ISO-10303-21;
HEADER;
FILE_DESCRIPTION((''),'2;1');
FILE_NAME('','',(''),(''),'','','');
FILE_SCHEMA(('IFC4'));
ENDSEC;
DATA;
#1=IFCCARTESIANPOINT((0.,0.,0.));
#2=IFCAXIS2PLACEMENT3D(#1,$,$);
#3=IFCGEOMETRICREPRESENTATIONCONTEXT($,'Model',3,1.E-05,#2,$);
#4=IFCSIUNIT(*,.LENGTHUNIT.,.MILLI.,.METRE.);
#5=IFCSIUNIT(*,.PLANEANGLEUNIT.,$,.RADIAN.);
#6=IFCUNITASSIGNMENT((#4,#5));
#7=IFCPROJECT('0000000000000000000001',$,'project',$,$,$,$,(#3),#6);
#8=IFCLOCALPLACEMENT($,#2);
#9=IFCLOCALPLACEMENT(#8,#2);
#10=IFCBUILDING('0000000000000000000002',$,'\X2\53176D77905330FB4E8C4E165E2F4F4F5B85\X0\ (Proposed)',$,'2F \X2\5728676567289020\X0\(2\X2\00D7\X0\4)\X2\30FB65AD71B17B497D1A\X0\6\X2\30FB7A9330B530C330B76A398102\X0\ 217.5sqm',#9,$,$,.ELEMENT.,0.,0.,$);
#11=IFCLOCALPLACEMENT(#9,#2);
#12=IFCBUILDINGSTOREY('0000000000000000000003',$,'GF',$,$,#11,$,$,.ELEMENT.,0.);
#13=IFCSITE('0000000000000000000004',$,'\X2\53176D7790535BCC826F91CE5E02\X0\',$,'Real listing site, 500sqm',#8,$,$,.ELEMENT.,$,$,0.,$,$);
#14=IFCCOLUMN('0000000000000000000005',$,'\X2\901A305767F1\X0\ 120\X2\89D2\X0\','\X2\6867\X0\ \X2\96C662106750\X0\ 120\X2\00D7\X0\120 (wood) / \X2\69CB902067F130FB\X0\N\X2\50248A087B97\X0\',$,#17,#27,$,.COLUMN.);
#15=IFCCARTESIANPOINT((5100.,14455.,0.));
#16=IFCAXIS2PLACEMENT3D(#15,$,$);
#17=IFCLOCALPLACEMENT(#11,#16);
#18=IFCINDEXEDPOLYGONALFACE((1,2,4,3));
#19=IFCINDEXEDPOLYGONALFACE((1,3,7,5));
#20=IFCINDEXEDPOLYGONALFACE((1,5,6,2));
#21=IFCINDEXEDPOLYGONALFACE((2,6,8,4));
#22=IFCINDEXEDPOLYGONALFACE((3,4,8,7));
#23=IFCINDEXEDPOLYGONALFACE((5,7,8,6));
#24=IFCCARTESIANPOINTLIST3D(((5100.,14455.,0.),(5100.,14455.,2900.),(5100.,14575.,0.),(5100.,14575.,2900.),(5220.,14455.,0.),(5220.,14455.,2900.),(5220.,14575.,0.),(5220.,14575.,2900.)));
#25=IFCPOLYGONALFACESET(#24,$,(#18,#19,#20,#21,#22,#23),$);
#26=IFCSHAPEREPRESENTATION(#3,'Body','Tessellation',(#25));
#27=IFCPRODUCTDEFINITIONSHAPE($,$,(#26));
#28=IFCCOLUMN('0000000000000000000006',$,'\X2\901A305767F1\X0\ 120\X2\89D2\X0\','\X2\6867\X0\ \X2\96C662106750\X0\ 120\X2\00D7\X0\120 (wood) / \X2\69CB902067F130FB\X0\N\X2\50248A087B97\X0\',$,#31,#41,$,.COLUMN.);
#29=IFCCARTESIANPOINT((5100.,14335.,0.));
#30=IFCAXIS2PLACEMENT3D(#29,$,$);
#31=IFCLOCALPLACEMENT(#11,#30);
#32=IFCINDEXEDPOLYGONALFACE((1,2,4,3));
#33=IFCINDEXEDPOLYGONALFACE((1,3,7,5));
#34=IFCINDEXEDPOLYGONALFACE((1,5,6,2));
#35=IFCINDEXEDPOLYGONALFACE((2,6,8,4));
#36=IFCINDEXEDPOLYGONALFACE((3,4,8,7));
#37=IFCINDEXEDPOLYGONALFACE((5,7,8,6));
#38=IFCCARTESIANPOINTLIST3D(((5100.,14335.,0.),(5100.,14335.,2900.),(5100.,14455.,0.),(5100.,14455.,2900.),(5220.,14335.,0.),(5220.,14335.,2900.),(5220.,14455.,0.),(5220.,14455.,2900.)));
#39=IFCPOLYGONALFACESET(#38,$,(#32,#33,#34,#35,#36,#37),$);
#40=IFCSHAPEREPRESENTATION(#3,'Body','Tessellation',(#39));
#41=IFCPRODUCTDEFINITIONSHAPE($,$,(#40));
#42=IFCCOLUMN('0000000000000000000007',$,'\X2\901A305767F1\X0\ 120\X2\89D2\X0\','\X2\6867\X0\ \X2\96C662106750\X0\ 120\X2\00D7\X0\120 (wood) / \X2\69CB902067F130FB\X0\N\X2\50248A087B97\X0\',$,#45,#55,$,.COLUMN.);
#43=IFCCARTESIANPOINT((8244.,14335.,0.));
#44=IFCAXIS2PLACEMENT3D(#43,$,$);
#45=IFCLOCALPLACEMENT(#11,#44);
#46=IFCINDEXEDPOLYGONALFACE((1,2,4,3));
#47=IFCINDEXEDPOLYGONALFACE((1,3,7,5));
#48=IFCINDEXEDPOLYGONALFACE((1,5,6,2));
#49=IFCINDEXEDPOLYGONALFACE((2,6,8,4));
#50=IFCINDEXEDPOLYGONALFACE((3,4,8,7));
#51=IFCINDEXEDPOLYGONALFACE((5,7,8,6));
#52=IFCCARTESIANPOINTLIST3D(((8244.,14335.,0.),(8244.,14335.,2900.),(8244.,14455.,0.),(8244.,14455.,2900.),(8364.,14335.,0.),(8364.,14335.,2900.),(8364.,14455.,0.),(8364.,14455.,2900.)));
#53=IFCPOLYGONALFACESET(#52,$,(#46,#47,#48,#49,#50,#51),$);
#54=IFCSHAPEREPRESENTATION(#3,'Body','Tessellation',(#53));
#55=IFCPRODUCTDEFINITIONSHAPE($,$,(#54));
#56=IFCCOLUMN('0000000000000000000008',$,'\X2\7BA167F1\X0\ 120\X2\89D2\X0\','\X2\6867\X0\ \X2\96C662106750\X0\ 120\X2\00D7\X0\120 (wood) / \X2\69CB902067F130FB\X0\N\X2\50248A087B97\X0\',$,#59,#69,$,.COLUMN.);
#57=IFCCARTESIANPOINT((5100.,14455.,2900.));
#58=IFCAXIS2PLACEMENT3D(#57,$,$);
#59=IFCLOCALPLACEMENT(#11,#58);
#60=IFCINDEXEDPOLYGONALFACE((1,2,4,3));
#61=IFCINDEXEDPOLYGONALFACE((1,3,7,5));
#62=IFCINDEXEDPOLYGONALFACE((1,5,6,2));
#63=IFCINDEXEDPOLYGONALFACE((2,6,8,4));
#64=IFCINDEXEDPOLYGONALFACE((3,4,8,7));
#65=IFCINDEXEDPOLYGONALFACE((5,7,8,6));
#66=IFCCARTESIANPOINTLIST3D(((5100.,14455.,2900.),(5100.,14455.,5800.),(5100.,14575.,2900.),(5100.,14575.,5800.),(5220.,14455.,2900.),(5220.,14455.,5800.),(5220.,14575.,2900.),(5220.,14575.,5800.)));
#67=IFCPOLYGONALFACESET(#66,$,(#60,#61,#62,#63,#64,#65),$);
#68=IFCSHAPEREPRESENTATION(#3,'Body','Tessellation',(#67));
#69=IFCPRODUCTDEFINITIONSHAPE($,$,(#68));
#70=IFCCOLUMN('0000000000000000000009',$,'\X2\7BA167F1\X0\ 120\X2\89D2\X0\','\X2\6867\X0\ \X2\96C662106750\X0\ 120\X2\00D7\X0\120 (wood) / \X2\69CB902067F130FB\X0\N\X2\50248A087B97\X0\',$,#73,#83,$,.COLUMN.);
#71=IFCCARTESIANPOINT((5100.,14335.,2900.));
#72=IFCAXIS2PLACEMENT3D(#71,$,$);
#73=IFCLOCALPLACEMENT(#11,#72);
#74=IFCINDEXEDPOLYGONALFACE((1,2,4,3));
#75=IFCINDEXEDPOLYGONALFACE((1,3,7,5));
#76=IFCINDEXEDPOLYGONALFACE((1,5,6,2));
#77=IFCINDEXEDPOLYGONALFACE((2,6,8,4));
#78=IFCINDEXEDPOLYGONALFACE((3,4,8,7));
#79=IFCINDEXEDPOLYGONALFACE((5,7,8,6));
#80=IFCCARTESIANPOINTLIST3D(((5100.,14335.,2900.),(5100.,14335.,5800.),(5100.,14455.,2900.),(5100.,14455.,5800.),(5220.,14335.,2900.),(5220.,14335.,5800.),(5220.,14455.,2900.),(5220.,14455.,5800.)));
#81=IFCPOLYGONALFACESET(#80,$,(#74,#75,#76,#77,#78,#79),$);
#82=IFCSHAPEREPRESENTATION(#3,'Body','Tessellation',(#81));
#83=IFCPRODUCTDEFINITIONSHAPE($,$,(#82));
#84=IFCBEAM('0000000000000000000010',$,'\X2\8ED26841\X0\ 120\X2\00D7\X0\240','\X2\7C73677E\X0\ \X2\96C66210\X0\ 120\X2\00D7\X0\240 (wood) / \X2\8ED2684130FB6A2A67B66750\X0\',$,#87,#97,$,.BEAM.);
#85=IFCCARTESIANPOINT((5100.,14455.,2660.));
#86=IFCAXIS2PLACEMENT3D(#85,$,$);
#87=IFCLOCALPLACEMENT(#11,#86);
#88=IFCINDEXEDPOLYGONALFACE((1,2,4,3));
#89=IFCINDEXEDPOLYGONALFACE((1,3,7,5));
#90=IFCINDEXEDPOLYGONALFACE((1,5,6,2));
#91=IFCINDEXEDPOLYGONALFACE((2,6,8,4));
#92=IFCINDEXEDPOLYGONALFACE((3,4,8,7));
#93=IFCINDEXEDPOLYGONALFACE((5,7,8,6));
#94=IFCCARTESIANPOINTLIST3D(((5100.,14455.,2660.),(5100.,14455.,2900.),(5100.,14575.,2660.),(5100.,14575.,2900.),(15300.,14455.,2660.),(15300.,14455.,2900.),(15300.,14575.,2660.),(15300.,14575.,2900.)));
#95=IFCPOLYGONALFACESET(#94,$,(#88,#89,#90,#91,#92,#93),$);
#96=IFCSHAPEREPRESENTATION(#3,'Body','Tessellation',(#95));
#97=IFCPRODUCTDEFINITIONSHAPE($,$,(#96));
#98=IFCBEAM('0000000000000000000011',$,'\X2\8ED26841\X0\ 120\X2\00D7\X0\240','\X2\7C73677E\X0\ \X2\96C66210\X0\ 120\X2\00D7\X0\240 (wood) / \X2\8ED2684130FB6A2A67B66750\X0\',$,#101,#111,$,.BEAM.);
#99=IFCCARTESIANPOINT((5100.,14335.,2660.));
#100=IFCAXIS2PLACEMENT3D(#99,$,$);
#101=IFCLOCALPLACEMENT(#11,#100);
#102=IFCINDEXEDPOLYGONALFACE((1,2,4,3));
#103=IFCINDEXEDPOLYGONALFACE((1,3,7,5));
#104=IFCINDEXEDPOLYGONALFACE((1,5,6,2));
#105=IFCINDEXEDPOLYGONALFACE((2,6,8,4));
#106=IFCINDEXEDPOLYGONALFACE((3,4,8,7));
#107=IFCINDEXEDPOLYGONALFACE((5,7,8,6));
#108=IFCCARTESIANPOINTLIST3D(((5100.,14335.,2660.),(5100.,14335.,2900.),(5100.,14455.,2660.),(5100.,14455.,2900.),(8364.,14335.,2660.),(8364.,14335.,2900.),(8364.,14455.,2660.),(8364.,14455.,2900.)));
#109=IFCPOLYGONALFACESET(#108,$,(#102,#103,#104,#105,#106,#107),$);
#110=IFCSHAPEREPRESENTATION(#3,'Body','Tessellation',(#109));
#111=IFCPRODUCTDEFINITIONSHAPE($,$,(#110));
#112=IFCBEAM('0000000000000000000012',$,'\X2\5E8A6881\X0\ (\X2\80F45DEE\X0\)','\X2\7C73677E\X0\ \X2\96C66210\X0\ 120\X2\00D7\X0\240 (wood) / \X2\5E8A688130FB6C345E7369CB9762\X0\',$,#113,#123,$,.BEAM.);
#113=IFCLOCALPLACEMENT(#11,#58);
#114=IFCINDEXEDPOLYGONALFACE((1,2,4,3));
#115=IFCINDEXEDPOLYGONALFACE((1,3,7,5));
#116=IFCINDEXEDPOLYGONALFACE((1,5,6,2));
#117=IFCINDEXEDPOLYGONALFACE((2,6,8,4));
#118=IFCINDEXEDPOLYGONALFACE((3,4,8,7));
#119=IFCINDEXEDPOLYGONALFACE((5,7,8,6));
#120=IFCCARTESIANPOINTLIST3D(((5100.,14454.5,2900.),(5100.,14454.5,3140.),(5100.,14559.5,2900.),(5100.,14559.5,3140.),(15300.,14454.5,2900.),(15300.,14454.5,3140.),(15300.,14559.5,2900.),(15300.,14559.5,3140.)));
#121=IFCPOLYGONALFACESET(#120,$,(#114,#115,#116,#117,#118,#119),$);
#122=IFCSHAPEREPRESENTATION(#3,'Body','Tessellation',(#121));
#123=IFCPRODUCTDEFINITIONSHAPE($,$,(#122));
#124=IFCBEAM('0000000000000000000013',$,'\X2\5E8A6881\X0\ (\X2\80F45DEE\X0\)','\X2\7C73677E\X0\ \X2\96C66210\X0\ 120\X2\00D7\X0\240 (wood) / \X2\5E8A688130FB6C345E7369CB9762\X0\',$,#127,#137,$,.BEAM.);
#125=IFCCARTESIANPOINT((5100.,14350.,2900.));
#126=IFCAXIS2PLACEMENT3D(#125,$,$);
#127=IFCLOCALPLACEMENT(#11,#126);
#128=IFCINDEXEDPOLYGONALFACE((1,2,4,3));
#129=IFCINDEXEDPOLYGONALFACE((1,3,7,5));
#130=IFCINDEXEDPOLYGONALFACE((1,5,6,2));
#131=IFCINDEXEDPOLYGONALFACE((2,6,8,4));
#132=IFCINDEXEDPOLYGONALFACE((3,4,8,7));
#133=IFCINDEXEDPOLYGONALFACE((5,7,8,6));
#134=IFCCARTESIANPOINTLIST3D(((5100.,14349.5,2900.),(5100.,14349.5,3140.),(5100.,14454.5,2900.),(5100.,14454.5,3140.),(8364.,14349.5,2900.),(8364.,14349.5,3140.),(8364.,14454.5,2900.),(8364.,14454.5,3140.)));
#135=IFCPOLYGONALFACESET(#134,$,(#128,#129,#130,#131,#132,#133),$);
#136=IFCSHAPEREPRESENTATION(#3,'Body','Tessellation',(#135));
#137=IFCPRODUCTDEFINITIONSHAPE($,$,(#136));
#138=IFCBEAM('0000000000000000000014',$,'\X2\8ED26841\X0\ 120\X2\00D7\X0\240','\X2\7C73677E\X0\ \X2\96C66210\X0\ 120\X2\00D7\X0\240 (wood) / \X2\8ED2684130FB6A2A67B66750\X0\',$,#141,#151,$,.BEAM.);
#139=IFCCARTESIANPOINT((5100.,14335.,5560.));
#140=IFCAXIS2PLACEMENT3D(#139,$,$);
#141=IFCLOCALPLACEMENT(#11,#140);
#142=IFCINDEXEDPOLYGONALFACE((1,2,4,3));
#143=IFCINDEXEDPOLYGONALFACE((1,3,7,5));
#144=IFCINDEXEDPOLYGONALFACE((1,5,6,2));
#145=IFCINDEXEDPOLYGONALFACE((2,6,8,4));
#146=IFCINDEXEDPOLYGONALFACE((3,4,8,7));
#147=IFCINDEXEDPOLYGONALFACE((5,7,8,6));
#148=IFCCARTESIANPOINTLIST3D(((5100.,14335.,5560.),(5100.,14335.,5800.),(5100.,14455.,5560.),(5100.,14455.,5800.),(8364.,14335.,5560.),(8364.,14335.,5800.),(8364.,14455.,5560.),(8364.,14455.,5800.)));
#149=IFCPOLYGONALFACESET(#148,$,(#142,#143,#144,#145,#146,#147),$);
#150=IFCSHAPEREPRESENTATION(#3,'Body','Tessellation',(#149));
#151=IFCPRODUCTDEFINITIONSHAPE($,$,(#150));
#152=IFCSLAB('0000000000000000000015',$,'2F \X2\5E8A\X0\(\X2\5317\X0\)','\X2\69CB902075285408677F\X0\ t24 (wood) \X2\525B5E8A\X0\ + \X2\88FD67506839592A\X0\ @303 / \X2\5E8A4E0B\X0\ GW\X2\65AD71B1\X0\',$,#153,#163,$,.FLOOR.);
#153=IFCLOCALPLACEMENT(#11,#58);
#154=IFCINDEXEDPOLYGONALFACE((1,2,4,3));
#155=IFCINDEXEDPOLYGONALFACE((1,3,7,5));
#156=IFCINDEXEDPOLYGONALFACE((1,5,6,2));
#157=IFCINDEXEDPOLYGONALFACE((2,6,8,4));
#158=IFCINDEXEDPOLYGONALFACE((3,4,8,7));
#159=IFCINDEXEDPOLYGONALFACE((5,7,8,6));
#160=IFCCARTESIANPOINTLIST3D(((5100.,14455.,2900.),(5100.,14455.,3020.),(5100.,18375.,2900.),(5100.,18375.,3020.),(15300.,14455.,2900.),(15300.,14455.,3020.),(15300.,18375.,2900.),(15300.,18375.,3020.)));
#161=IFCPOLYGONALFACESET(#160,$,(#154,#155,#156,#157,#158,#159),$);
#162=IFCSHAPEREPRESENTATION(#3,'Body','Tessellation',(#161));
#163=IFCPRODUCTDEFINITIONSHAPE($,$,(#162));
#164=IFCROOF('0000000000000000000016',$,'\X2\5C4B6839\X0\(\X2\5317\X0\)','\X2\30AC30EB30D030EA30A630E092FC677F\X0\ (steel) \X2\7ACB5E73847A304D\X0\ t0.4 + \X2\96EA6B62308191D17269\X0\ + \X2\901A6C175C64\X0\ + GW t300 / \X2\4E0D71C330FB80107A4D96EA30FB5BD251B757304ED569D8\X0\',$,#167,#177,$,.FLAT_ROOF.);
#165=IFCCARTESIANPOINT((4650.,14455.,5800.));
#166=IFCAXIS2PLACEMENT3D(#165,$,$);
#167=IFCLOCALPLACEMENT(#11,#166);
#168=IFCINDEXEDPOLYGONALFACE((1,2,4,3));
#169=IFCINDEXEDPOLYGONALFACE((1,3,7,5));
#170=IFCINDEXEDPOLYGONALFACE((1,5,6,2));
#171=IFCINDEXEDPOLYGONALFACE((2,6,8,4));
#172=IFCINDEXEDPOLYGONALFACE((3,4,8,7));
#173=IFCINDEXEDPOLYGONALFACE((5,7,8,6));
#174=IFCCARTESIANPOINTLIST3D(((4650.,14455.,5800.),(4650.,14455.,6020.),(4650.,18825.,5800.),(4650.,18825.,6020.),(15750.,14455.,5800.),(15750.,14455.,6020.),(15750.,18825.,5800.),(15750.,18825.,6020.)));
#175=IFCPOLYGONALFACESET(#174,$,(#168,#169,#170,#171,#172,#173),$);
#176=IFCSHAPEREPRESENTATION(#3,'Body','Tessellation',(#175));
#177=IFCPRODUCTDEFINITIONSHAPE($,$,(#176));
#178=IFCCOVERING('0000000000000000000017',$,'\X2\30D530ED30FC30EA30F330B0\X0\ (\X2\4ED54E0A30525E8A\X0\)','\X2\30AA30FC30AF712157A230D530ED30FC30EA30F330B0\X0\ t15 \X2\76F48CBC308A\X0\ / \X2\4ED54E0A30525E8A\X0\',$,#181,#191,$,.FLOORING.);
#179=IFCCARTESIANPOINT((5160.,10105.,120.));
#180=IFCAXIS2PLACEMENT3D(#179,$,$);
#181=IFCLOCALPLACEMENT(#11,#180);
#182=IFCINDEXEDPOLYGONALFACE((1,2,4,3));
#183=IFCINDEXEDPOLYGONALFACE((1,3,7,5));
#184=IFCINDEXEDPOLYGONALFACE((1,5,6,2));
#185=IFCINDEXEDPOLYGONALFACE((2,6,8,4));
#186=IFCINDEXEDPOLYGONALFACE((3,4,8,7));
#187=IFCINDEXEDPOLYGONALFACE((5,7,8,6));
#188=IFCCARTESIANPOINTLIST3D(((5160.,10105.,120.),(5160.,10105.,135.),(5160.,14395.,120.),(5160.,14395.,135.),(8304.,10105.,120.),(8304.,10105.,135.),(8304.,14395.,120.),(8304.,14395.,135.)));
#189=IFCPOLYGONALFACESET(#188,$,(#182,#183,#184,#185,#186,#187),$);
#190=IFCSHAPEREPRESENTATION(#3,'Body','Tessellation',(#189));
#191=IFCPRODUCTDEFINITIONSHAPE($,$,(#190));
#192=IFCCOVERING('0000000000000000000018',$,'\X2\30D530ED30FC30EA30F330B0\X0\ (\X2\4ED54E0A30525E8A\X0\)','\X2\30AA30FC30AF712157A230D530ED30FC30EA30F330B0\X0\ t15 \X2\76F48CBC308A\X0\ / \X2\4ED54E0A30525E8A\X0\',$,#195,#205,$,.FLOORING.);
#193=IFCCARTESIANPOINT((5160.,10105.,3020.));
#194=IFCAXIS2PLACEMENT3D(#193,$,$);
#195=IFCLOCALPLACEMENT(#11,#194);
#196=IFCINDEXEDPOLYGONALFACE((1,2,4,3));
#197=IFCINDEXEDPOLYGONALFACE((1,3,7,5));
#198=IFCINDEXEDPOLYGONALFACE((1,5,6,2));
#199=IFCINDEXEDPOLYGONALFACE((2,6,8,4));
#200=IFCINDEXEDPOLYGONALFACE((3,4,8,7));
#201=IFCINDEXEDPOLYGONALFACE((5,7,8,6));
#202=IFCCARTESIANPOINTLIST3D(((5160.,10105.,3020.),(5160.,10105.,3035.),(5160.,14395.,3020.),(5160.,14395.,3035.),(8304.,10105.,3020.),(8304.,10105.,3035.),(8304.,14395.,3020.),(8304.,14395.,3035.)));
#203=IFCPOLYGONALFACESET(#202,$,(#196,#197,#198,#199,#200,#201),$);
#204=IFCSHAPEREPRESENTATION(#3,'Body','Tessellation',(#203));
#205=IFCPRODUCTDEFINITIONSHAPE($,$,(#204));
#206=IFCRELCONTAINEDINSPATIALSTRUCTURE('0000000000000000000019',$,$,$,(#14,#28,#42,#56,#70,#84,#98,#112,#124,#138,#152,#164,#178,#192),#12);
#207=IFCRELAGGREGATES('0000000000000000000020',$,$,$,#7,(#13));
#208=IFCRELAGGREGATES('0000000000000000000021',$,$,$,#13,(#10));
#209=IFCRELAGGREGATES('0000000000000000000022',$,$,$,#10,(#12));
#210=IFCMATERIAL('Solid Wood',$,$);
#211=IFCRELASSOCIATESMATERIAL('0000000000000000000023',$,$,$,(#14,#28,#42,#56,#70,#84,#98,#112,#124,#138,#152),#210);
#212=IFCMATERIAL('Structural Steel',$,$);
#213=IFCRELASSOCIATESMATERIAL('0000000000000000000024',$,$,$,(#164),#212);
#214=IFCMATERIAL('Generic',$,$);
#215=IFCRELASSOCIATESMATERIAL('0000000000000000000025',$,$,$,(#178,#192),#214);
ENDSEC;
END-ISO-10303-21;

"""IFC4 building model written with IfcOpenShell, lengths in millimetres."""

from ifc_helpers import new_model, si_unit, frame, frame_2d, origin, place, context, project, spatial, rectangle, extrude, material, element, save


model = new_model("IFC4")

# Units and contexts
model_context = context("Model", 3, precision=1e-05, world=origin())
ifc_project = project(units=[si_unit("LENGTHUNIT", "METRE", prefix="MILLI"), si_unit("PLANEANGLEUNIT", "RADIAN")], contexts=[model_context])

# Site, building, storey
site_placement = place(None, origin())
site = spatial("IfcSite", under=ifc_project, at=site_placement, Name="北海道富良野市", ObjectType="Real listing site, 500sqm", CompositionType="ELEMENT", RefElevation=0.0)
building_placement = place(site_placement, origin())
building = spatial("IfcBuilding", under=site, at=building_placement, Name="北海道・二世帯住宅 (Proposed)", ObjectType="2F 在来木造(2×4)・断熱等級6・窓サッシ樹脂 217.5sqm", CompositionType="ELEMENT", ElevationOfRefHeight=0.0, ElevationOfTerrain=0.0)
storey_placement = place(building_placement, origin())
storey = spatial("IfcBuildingStorey", under=building, at=storey_placement, Name="GF", CompositionType="ELEMENT", Elevation=0.0)

# Columns
ifc_material_1 = material(Name="Solid Wood")
column_1_placement = place(storey_placement, frame((5100.0, 14455.0, 0.0)))
element("IfcColumn", 1, at=column_1_placement, inside=storey, material=ifc_material_1, Name="通し柱 120角", Description="桧 集成材 120×120 (wood) / 構造柱・N値計算", PredefinedType="COLUMN", context=model_context, shape_type="SweptSolid", body=[
    extrude(rectangle(XDim=120.0, YDim=120.0, at=frame_2d((60.0, 60.0))), frame((5100.0, 14455.0, 0.0)), (0.0, 0.0, 1.0), 2900.0),
])
column_2_placement = place(storey_placement, frame((5100.0, 14335.0, 0.0)))
element("IfcColumn", 2, at=column_2_placement, inside=storey, material=ifc_material_1, Name="通し柱 120角", Description="桧 集成材 120×120 (wood) / 構造柱・N値計算", PredefinedType="COLUMN", context=model_context, shape_type="SweptSolid", body=[
    extrude(rectangle(XDim=120.0, YDim=120.0, at=frame_2d((60.0, 60.0))), frame((5100.0, 14335.0, 0.0)), (0.0, 0.0, 1.0), 2900.0),
])
column_3_placement = place(storey_placement, frame((8244.0, 14335.0, 0.0)))
element("IfcColumn", 3, at=column_3_placement, inside=storey, material=ifc_material_1, Name="通し柱 120角", Description="桧 集成材 120×120 (wood) / 構造柱・N値計算", PredefinedType="COLUMN", context=model_context, shape_type="SweptSolid", body=[
    extrude(rectangle(XDim=120.0, YDim=120.0, at=frame_2d((60.0, 60.0))), frame((8244.0, 14335.0, 0.0)), (0.0, 0.0, 1.0), 2900.0),
])
column_4_placement = place(storey_placement, frame((5100.0, 14455.0, 2900.0)))
element("IfcColumn", 4, at=column_4_placement, inside=storey, material=ifc_material_1, Name="管柱 120角", Description="桧 集成材 120×120 (wood) / 構造柱・N値計算", PredefinedType="COLUMN", context=model_context, shape_type="SweptSolid", body=[
    extrude(rectangle(XDim=120.0, YDim=120.0, at=frame_2d((60.0, 60.0))), frame((5100.0, 14455.0, 2900.0)), (0.0, 0.0, 1.0), 2900.0),
])
column_5_placement = place(storey_placement, frame((5100.0, 14335.0, 2900.0)))
element("IfcColumn", 5, at=column_5_placement, inside=storey, material=ifc_material_1, Name="管柱 120角", Description="桧 集成材 120×120 (wood) / 構造柱・N値計算", PredefinedType="COLUMN", context=model_context, shape_type="SweptSolid", body=[
    extrude(rectangle(XDim=120.0, YDim=120.0, at=frame_2d((60.0, 60.0))), frame((5100.0, 14335.0, 2900.0)), (0.0, 0.0, 1.0), 2900.0),
])

# Beams
beam_1_placement = place(storey_placement, frame((5100.0, 14455.0, 2660.0)))
element("IfcBeam", 6, at=beam_1_placement, inside=storey, material=ifc_material_1, Name="軒桁 120×240", Description="米松 集成 120×240 (wood) / 軒桁・横架材", PredefinedType="BEAM", context=model_context, shape_type="SweptSolid", body=[
    extrude(rectangle(XDim=10200.0, YDim=120.0, at=frame_2d((5100.0, 60.0))), frame((5100.0, 14455.0, 2660.0)), (0.0, 0.0, 1.0), 240.0),
])
beam_2_placement = place(storey_placement, frame((5100.0, 14335.0, 2660.0)))
element("IfcBeam", 7, at=beam_2_placement, inside=storey, material=ifc_material_1, Name="軒桁 120×240", Description="米松 集成 120×240 (wood) / 軒桁・横架材", PredefinedType="BEAM", context=model_context, shape_type="SweptSolid", body=[
    extrude(rectangle(XDim=3264.0, YDim=120.0, at=frame_2d((1632.0, 60.0))), frame((5100.0, 14335.0, 2660.0)), (0.0, 0.0, 1.0), 240.0),
])
beam_3_placement = place(storey_placement, frame((5100.0, 14455.0, 2900.0)))
element("IfcBeam", 8, at=beam_3_placement, inside=storey, material=ifc_material_1, Name="床梁 (胴差)", Description="米松 集成 120×240 (wood) / 床梁・水平構面", PredefinedType="BEAM", context=model_context, shape_type="SweptSolid", body=[
    extrude(rectangle(XDim=10200.0, YDim=105.0, at=frame_2d((5100.0, 52.0))), frame((5100.0, 14455.0, 2900.0)), (0.0, 0.0, 1.0), 240.0),
])
beam_4_placement = place(storey_placement, frame((5100.0, 14350.0, 2900.0)))
element("IfcBeam", 9, at=beam_4_placement, inside=storey, material=ifc_material_1, Name="床梁 (胴差)", Description="米松 集成 120×240 (wood) / 床梁・水平構面", PredefinedType="BEAM", context=model_context, shape_type="SweptSolid", body=[
    extrude(rectangle(XDim=3264.0, YDim=105.0, at=frame_2d((1632.0, 52.0))), frame((5100.0, 14350.0, 2900.0)), (0.0, 0.0, 1.0), 240.0),
])
beam_5_placement = place(storey_placement, frame((5100.0, 14335.0, 5560.0)))
element("IfcBeam", 10, at=beam_5_placement, inside=storey, material=ifc_material_1, Name="軒桁 120×240", Description="米松 集成 120×240 (wood) / 軒桁・横架材", PredefinedType="BEAM", context=model_context, shape_type="SweptSolid", body=[
    extrude(rectangle(XDim=3264.0, YDim=120.0, at=frame_2d((1632.0, 60.0))), frame((5100.0, 14335.0, 5560.0)), (0.0, 0.0, 1.0), 240.0),
])

# Slab
slab_1_placement = place(storey_placement, frame((5100.0, 14455.0, 2900.0)))
element("IfcSlab", 11, at=slab_1_placement, inside=storey, material=ifc_material_1, Name="2F 床(北)", Description="構造用合板 t24 (wood) 剛床 + 製材根太 @303 / 床下 GW断熱", PredefinedType="FLOOR", context=model_context, shape_type="SweptSolid", body=[
    extrude(rectangle(XDim=10200.0, YDim=3920.0, at=frame_2d((5100.0, 1960.0))), frame((5100.0, 14455.0, 2900.0)), (0.0, 0.0, 1.0), 120.0),
])

# Roof
ifc_material_2 = material(Name="Structural Steel")
for number, where, name in (
    (12, (4650.0, 14455.0, 5800.0), "屋根(北)"),
):
    element("IfcRoof", number, at=place(storey_placement, frame(where)), inside=storey, material=ifc_material_2, Name=name, Description="ガルバリウム鋼板 (steel) 立平葺き t0.4 + 雪止め金物 + 通気層 + GW t300 / 不燃・耐積雪・寒冷地仕様", PredefinedType="FLAT_ROOF", context=model_context, shape_type="SweptSolid", body=[
        extrude(rectangle(XDim=11100.0, YDim=4370.0, at=frame_2d((5550.0, 2185.0))), frame((4650.0, 14455.0, 5800.0)), (0.0, 0.0, 1.0), 220.0),
    ])

# Coverings
ifc_material_3 = material(Name="Generic")
covering_1_placement = place(storey_placement, frame((5160.0, 10105.0, 120.0)))
element("IfcCovering", 13, at=covering_1_placement, inside=storey, material=ifc_material_3, Name="フローリング (仕上げ床)", Description="オーク無垢フローリング t15 直貼り / 仕上げ床", PredefinedType="FLOORING", context=model_context, shape_type="SweptSolid", body=[
    extrude(rectangle(XDim=3144.0, YDim=4290.0, at=frame_2d((1572.0, 2145.0))), frame((5160.0, 10105.0, 120.0)), (0.0, 0.0, 1.0), 15.0),
])
covering_2_placement = place(storey_placement, frame((5160.0, 10105.0, 3020.0)))
element("IfcCovering", 14, at=covering_2_placement, inside=storey, material=ifc_material_3, Name="フローリング (仕上げ床)", Description="オーク無垢フローリング t15 直貼り / 仕上げ床", PredefinedType="FLOORING", context=model_context, shape_type="SweptSolid", body=[
    extrude(rectangle(XDim=3144.0, YDim=4290.0, at=frame_2d((1572.0, 2145.0))), frame((5160.0, 10105.0, 3020.0)), (0.0, 0.0, 1.0), 15.0),
])

save(model, "model.ifc")
